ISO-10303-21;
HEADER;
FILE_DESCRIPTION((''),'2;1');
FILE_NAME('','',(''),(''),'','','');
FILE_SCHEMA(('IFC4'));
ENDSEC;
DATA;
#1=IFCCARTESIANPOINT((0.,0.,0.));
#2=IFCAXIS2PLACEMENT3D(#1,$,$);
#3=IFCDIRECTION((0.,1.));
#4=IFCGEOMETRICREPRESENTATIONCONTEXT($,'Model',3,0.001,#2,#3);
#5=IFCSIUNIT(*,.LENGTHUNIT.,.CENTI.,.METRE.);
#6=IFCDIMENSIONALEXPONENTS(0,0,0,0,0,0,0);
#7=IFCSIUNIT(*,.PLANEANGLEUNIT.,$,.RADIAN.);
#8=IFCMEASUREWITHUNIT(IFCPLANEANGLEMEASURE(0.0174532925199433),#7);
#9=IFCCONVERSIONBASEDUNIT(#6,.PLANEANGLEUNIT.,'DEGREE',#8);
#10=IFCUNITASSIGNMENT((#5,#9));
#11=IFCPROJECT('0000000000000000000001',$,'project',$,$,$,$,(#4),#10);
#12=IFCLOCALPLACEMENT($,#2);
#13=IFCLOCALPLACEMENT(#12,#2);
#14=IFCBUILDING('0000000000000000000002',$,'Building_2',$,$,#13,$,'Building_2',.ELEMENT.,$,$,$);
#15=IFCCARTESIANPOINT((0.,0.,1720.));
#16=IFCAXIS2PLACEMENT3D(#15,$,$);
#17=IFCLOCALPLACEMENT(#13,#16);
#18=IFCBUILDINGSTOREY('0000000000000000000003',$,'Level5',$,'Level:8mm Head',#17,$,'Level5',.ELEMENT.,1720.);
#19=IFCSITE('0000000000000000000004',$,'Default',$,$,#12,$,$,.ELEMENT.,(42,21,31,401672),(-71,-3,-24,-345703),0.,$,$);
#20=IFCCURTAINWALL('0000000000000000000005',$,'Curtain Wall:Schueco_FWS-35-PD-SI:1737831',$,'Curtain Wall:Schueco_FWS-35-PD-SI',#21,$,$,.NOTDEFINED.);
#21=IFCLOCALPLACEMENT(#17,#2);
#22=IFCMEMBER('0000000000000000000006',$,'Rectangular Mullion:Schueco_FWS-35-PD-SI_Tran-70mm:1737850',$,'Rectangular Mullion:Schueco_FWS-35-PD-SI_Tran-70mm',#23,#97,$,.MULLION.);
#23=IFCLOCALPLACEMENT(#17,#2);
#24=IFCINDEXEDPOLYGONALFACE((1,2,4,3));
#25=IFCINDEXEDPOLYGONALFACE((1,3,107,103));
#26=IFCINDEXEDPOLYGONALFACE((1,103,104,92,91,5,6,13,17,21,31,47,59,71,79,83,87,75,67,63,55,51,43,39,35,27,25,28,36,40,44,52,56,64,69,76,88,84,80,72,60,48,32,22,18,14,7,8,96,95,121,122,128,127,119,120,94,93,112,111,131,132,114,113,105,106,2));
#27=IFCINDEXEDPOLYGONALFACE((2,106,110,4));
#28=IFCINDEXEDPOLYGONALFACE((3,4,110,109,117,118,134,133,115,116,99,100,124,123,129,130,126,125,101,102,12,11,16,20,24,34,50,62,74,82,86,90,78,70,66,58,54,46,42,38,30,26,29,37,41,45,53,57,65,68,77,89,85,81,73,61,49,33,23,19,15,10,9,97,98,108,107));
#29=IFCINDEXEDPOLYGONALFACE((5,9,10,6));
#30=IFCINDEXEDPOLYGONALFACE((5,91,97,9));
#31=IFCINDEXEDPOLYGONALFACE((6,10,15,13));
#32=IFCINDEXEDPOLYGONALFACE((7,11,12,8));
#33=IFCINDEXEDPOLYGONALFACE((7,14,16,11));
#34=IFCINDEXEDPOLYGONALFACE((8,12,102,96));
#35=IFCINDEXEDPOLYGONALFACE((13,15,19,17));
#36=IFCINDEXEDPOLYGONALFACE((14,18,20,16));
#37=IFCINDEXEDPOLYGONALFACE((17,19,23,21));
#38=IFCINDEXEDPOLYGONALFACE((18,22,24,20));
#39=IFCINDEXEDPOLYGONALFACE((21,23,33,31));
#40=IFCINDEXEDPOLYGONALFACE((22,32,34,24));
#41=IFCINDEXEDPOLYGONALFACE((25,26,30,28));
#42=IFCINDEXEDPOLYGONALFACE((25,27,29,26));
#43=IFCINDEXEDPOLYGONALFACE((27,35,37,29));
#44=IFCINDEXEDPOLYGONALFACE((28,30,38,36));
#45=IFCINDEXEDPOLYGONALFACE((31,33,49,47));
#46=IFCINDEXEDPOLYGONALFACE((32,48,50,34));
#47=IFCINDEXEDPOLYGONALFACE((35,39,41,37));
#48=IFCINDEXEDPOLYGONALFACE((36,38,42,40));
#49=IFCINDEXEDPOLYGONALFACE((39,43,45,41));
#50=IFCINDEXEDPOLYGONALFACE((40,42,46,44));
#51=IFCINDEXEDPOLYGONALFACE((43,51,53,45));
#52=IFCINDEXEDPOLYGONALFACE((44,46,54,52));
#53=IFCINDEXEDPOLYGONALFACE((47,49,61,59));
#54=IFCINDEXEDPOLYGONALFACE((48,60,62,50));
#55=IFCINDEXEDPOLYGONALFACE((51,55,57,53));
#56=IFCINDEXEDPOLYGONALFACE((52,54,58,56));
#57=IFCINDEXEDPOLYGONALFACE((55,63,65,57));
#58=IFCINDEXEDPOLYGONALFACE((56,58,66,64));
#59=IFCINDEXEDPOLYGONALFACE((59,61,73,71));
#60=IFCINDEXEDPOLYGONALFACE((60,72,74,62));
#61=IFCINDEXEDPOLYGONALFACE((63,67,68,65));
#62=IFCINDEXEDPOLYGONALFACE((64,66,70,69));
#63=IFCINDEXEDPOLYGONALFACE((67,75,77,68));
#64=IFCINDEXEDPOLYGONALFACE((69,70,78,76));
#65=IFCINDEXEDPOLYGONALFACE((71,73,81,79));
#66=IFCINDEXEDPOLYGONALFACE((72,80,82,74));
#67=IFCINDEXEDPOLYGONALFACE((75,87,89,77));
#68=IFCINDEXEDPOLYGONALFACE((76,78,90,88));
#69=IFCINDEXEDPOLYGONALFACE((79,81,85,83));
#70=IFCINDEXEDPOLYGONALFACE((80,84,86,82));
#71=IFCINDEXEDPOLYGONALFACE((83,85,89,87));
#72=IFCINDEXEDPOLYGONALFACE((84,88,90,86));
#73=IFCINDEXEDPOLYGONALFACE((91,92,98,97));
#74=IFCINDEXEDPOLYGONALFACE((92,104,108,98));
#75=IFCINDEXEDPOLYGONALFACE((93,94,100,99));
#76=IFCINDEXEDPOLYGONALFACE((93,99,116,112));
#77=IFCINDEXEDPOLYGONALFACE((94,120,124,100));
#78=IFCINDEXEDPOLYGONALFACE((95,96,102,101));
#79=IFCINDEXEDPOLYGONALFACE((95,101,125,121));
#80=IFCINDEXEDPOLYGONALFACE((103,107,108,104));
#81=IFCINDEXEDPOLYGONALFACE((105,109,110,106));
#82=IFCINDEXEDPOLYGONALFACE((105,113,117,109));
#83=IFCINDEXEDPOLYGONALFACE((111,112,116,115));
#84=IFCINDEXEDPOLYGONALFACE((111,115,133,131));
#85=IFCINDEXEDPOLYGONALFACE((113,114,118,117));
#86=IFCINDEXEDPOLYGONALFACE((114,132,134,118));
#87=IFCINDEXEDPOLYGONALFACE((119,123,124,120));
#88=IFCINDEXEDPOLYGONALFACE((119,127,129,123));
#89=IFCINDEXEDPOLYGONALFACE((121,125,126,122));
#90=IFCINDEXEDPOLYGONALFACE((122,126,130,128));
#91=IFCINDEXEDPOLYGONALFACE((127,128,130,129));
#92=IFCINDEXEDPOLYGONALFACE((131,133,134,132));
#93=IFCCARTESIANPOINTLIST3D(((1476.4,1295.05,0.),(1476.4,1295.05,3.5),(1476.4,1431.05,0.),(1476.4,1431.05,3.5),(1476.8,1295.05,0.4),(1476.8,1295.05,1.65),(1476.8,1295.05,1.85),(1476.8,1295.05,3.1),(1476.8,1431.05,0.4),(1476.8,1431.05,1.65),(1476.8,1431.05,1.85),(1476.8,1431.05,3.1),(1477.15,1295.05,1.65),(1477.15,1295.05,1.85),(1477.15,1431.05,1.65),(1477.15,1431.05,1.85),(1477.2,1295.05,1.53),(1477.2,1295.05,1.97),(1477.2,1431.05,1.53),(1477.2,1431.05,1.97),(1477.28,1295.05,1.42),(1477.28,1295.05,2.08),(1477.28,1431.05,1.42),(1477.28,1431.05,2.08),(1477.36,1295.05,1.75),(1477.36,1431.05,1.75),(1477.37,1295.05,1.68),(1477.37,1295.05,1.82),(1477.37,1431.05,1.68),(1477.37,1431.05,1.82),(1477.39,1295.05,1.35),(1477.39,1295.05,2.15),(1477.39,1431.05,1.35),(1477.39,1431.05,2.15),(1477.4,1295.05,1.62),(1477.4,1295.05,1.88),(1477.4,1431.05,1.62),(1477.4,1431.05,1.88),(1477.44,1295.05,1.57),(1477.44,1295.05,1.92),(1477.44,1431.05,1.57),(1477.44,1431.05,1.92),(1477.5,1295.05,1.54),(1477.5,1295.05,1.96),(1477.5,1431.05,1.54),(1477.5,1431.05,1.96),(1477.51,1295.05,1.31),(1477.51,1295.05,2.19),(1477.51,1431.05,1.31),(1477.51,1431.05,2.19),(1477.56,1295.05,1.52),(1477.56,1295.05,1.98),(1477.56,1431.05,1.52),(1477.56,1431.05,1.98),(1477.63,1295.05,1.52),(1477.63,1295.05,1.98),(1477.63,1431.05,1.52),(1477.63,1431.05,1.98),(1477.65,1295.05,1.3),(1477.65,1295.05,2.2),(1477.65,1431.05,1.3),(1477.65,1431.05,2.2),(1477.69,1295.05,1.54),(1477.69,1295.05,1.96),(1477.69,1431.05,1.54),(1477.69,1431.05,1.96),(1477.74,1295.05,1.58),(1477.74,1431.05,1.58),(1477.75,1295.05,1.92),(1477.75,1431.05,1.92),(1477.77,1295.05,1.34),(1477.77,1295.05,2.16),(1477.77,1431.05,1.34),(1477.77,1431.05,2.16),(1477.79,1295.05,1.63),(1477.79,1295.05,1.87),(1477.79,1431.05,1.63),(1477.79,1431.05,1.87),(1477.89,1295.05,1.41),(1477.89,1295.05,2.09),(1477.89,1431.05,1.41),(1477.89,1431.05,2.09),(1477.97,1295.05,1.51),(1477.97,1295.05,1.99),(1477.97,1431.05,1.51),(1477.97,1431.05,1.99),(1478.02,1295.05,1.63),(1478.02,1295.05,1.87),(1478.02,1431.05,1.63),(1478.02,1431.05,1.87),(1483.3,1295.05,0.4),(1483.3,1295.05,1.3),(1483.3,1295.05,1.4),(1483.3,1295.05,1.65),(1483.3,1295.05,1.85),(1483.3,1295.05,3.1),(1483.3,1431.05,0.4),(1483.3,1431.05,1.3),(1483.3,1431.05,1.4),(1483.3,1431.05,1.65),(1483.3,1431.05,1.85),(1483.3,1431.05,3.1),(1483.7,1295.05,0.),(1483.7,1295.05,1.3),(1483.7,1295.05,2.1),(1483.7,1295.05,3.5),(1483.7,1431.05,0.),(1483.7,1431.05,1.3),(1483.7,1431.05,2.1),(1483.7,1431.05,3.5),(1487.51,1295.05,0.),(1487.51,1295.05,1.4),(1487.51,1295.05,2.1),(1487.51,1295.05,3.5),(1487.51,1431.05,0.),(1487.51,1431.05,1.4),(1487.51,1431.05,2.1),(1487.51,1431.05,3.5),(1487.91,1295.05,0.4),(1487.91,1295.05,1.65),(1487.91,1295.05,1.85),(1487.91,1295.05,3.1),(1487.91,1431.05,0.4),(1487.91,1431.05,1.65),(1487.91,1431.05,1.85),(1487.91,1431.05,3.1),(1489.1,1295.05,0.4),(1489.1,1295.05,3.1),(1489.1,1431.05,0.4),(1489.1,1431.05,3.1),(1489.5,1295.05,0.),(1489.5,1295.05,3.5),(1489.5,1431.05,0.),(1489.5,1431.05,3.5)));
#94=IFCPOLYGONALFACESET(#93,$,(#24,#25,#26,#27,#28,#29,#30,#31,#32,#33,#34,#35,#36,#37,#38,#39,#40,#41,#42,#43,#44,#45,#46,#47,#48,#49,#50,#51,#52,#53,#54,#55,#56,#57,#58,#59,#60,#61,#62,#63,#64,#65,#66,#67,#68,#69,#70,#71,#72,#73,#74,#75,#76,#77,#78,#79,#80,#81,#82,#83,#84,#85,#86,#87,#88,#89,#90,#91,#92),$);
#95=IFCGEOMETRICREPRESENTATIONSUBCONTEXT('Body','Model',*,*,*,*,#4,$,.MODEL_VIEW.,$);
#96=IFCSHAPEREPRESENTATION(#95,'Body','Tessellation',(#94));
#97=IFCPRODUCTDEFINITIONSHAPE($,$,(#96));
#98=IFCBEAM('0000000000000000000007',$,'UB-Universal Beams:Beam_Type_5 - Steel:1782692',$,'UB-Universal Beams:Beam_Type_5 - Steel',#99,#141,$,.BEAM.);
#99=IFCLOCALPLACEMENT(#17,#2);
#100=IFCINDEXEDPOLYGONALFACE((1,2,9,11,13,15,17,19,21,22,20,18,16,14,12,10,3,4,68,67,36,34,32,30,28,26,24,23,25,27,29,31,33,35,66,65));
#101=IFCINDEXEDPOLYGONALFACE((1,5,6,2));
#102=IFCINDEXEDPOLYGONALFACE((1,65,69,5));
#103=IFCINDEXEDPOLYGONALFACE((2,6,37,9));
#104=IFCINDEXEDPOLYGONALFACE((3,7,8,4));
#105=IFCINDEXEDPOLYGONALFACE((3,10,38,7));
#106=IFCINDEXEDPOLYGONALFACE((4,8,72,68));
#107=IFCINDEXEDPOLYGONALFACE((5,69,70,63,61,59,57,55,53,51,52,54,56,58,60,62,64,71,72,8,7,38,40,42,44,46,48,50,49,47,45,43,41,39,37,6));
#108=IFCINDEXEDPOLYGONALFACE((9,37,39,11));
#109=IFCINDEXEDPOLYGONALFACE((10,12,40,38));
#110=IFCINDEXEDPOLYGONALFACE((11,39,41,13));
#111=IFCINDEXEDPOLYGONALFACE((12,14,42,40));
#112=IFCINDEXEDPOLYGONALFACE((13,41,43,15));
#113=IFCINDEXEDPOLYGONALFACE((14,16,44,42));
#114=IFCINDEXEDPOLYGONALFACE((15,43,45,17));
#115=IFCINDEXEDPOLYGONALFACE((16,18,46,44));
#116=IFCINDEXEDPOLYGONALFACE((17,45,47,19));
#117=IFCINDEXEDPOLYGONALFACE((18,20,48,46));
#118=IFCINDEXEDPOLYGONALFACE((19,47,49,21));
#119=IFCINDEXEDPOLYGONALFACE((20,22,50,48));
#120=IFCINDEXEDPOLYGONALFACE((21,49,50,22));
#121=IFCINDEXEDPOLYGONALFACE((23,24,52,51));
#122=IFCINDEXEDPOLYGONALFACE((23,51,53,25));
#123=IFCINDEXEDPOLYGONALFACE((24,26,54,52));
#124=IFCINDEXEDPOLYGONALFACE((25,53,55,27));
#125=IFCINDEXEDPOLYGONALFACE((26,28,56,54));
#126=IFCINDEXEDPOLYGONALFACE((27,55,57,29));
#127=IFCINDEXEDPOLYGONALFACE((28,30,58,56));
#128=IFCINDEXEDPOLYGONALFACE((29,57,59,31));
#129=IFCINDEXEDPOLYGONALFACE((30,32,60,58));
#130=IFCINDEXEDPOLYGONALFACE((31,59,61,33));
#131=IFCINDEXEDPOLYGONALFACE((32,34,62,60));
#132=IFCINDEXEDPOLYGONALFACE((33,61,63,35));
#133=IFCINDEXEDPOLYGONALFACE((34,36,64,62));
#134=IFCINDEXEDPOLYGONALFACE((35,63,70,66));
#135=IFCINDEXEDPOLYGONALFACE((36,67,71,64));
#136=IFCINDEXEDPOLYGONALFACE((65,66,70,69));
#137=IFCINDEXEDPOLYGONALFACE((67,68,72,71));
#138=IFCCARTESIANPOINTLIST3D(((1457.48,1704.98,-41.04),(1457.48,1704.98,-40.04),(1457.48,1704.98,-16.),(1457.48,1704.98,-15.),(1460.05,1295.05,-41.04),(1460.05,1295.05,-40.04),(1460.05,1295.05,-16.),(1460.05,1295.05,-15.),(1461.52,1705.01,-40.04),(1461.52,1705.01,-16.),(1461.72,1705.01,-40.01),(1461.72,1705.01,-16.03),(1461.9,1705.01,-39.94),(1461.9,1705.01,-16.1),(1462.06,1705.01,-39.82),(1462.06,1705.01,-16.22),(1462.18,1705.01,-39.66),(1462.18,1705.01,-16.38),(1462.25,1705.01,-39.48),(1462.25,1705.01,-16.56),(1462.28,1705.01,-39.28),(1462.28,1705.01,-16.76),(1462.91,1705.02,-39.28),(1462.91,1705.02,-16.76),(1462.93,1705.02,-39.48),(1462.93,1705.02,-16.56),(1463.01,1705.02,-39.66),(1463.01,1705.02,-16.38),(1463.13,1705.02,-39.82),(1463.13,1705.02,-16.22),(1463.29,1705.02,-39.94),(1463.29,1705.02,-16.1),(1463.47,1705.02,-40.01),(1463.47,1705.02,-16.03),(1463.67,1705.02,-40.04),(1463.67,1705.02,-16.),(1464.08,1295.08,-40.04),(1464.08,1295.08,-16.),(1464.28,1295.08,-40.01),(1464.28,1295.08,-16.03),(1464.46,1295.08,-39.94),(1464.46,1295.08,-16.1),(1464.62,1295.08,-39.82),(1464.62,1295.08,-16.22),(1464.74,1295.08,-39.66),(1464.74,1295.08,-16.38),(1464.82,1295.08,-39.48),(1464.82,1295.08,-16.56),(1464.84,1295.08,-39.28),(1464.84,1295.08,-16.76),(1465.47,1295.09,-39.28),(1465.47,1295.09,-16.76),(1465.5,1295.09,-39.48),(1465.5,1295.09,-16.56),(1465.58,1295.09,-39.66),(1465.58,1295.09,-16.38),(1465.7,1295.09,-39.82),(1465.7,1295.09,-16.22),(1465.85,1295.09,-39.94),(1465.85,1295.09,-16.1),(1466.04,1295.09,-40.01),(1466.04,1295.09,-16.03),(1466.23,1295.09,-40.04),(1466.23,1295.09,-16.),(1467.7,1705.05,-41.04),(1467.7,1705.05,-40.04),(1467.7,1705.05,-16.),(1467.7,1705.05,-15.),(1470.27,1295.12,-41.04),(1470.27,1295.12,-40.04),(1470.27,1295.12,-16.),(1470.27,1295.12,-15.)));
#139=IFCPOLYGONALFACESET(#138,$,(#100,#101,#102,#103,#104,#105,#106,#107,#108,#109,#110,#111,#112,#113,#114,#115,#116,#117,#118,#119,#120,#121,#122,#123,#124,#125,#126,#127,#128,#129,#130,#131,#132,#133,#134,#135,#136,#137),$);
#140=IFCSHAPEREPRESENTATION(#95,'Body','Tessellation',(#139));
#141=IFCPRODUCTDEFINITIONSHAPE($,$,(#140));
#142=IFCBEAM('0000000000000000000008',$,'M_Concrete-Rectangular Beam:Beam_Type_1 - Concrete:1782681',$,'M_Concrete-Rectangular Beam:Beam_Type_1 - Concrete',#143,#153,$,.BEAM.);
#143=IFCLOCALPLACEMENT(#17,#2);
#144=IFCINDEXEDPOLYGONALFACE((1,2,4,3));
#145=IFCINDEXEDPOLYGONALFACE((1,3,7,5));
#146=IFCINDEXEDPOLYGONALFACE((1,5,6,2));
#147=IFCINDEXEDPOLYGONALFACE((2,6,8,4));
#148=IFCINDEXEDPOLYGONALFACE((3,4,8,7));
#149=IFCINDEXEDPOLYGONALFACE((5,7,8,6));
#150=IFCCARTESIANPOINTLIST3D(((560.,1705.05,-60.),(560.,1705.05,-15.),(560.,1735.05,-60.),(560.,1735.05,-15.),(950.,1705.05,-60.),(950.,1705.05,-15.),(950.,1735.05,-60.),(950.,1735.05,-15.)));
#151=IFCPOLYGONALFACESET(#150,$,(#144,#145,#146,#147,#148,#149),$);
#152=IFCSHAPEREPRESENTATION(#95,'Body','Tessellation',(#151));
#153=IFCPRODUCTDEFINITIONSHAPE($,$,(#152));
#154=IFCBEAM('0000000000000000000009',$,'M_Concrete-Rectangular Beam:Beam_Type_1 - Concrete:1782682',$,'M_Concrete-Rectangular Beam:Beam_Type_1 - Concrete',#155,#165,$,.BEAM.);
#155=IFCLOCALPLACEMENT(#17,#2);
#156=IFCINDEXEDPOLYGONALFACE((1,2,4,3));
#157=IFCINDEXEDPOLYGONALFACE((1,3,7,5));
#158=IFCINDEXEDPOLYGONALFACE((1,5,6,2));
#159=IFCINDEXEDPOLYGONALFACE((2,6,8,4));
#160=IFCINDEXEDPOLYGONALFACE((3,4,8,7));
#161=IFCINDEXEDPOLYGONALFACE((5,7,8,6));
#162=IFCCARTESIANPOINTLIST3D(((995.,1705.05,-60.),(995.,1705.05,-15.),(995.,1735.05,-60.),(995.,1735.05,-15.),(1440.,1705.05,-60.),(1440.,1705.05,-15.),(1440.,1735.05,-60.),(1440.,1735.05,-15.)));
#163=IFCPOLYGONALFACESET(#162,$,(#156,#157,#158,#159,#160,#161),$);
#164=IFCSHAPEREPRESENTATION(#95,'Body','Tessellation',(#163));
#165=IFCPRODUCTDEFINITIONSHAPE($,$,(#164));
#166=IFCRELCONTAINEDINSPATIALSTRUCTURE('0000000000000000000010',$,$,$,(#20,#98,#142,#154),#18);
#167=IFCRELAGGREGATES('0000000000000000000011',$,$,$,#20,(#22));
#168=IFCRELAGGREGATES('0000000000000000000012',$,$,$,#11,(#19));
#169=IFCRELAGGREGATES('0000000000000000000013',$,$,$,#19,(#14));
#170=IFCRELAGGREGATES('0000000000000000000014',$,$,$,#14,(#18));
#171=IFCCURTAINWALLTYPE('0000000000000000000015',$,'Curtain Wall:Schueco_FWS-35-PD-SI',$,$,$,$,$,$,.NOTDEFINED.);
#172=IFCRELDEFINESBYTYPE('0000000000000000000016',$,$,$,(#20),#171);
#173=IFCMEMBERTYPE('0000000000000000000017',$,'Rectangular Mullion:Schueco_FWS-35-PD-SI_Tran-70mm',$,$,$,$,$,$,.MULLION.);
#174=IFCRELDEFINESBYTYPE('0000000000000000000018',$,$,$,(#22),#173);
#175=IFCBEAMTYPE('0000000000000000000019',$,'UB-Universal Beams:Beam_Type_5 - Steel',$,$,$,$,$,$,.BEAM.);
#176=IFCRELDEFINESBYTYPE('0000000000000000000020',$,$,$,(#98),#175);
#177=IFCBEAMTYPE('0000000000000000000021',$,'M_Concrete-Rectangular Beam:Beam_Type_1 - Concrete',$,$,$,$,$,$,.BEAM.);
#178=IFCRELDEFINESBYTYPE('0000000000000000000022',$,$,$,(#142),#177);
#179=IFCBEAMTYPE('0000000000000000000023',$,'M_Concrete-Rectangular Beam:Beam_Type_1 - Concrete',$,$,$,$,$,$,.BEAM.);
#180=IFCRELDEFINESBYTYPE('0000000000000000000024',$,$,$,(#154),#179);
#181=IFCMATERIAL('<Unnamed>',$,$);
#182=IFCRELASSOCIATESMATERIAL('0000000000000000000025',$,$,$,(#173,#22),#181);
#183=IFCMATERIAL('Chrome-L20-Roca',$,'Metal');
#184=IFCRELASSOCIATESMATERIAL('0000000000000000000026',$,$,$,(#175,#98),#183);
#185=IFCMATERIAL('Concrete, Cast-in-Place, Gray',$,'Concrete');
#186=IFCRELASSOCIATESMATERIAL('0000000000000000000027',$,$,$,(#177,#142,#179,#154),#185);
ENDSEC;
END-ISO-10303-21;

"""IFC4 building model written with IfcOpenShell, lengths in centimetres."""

from ifc_helpers import new_model, entity, si_unit, converted_unit, direction, frame, origin, place, context, subcontext, project, spatial, line, arc, indexed_curve, outline, extrude, source, transform, mapped, material, type_object, type_shapes, element, aggregate, save


model = new_model("IFC4")

# Units and contexts
model_context = context("Model", 3, precision=0.001, world=origin(), true_north=direction((0.0, 1.0)))
body_context = subcontext(model_context, "Body", "Model", "MODEL_VIEW")
ifc_project = project(units=[si_unit("LENGTHUNIT", "METRE", prefix="CENTI"), converted_unit("PLANEANGLEUNIT", "DEGREE", entity("IfcPlaneAngleMeasure", 0.0174532925199433), si_unit("PLANEANGLEUNIT", "RADIAN"), dimensions=[0, 0, 0, 0, 0, 0, 0])], contexts=[model_context])

# Site, building, storey
site_placement = place(None, origin())
site = spatial("IfcSite", under=ifc_project, at=site_placement, Name="Default", CompositionType="ELEMENT", RefLatitude=(42, 21, 31, 401672), RefLongitude=(-71, -3, -24, -345703), RefElevation=0.0)
building_placement = place(site_placement, origin())
building = spatial("IfcBuilding", under=site, at=building_placement, Name="Building_2", LongName="Building_2", CompositionType="ELEMENT")
storey_placement = place(building_placement, frame((0.0, 0.0, 1720.0)))
storey = spatial("IfcBuildingStorey", under=building, at=storey_placement, Name="Level5", ObjectType="Level:8mm Head", LongName="Level5", CompositionType="ELEMENT", Elevation=1720.0)

# Curtain wall, member
curtain_wall_type = type_object("IfcCurtainWallType", Name="Curtain Wall:Schueco_FWS-35-PD-SI", PredefinedType="NOTDEFINED")
curtain_wall_placement = place(storey_placement, frame((0.0, 0.0, -1720.0)))
curtain_wall = element("IfcCurtainWall", 1, at=curtain_wall_placement, inside=storey, type_object=curtain_wall_type, Name="Curtain Wall:Schueco_FWS-35-PD-SI:1737831", ObjectType="Curtain Wall:Schueco_FWS-35-PD-SI", PredefinedType="NOTDEFINED")
ifc_material_1 = material(Name="<Unnamed>")
member_type_1 = type_object("IfcMemberType", Name="Rectangular Mullion:Schueco_FWS-35-PD-SI_Tran-70mm", PredefinedType="MULLION", material=ifc_material_1)
shared_shape_1 = source(origin(), body_context, "Body", "SweptSolid", [
    extrude(outline(indexed_curve([(-6.52, -1.78), (0.78, -1.78), (0.78, -0.38), (4.59, -0.38), (4.59, -1.78), (6.58, -1.78), (6.58, 1.72), (4.59, 1.72), (4.59, 0.32), (0.38, 0.32), (0.38, 0.07), (4.99, 0.07), (4.99, 1.32), (6.18, 1.32), (6.18, -1.38), (4.99, -1.38), (4.99, -0.13), (0.38, -0.13), (0.38, -1.38), (-6.12, -1.38), (-6.12, -0.13), (-5.77, -0.13), (-5.34, -0.48), (-4.9, -0.15), (-5.14, -0.15), (-5.56, -0.03), (-5.14, 0.09), (-4.9, 0.09), (-5.34, 0.42), (-5.77, 0.07), (-6.12, 0.07), (-6.12, 1.32), (0.38, 1.32), (0.38, 0.42), (0.78, 0.42), (0.78, 1.72), (-6.52, 1.72)], segments=[line(1, 2, 3, 4, 5, 6, 7, 8, 9, 10, 11, 12, 13, 14, 15, 16, 17, 18, 19, 20, 21, 22), arc(22, 23, 24), line(24, 25), arc(25, 26, 27), line(27, 28), arc(28, 29, 30), line(30, 31, 32, 33, 34, 35, 36, 37, 1)], self_intersect=False)), frame((-1.72, 4.58, -136.0), z_axis=(0.0, 0.0, 1.0), x_axis=(0.0, -1.0, 0.0)), (0.0, 0.0, 1.0), 136.0),
])
type_shapes(member_type_1, [shared_shape_1])
member_1_placement = place(curtain_wall_placement, frame((1487.5, 1431.05, 1720.0), z_axis=(0.0, 1.0, 0.0), x_axis=(0.0, 0.0, -1.0)))
member_1 = element("IfcMember", 2, at=member_1_placement, type_object=member_type_1, material=ifc_material_1, Name="Rectangular Mullion:Schueco_FWS-35-PD-SI_Tran-70mm:1737850", ObjectType="Rectangular Mullion:Schueco_FWS-35-PD-SI_Tran-70mm", PredefinedType="MULLION", context=body_context, shape_type="MappedRepresentation", body=[
    mapped(shared_shape_1, transform((0.0, 0.0, 0.0), scale=1.0)),
])

# Beams
ifc_material_2 = material(Name="Chrome-L20-Roca", Category="Metal")
beam_type_1 = type_object("IfcBeamType", Name="UB-Universal Beams:Beam_Type_5 - Steel", PredefinedType="BEAM", material=ifc_material_2)
shared_shape_2 = source(origin(), body_context, "Body", "SweptSolid", [
    extrude(outline(indexed_curve([(-5.11, -12.02), (-5.11, -13.02), (5.11, -13.02), (5.11, -12.02), (1.08, -12.02), (0.54, -11.8), (0.31, -11.26), (0.31, 11.26), (0.54, 11.8), (1.07, 12.02), (5.11, 12.02), (5.11, 13.02), (-5.11, 13.02), (-5.11, 12.02), (-1.08, 12.02), (-0.54, 11.8), (-0.32, 11.26), (-0.32, -11.26), (-0.54, -11.8), (-1.08, -12.02)], segments=[line(1, 2, 3, 4, 5), arc(5, 6, 7), line(7, 8), arc(8, 9, 10), line(10, 11, 12, 13, 14, 15), arc(15, 16, 17), line(17, 18), arc(18, 19, 20), line(20, 1)], self_intersect=False)), frame((-199.97, 0.0, 0.0), z_axis=(-1.0, 0.0, 0.0), x_axis=(0.0, -1.0, 0.0)), (0.0, 0.0, -1.0), 409.94),
])
type_shapes(beam_type_1, [shared_shape_2])
beam_1_placement = place(storey_placement, frame((1463.85, 1505.05, -28.02), z_axis=(0.0, 0.0, 1.0), x_axis=(0.006256, -0.99998, 0.0)))
element("IfcBeam", 3, at=beam_1_placement, inside=storey, type_object=beam_type_1, material=ifc_material_2, Name="UB-Universal Beams:Beam_Type_5 - Steel:1782692", ObjectType="UB-Universal Beams:Beam_Type_5 - Steel", PredefinedType="BEAM", context=body_context, shape_type="MappedRepresentation", body=[
    mapped(shared_shape_2, transform((0.0, 0.0, 0.0), scale=1.0)),
])
ifc_material_3 = material(Name="Concrete, Cast-in-Place, Gray", Category="Concrete")
beam_type_2 = type_object("IfcBeamType", Name="M_Concrete-Rectangular Beam:Beam_Type_1 - Concrete", PredefinedType="BEAM", material=ifc_material_3)
shared_shape_3 = source(origin(), body_context, "Body", "SweptSolid", [
    extrude(outline(indexed_curve([(-22.5, -15.0), (22.5, -15.0), (22.5, 15.0), (-22.5, 15.0), (-22.5, -15.0)], self_intersect=False)), frame((560.0, 1720.05, 1682.5), z_axis=(1.0, 0.0, 0.0), x_axis=(0.0, 0.0, -1.0)), (0.0, 0.0, 1.0), 390.0),
])
type_shapes(beam_type_2, [shared_shape_3])
beam_2_placement = place(storey_placement, frame((0.0, 0.0, -1720.0)))
element("IfcBeam", 4, at=beam_2_placement, inside=storey, type_object=beam_type_2, material=ifc_material_3, Name="M_Concrete-Rectangular Beam:Beam_Type_1 - Concrete:1782681", ObjectType="M_Concrete-Rectangular Beam:Beam_Type_1 - Concrete", PredefinedType="BEAM", context=body_context, shape_type="MappedRepresentation", body=[
    mapped(shared_shape_3, transform((0.0, 0.0, 0.0), scale=1.0)),
])
beam_type_3 = type_object("IfcBeamType", Name="M_Concrete-Rectangular Beam:Beam_Type_1 - Concrete", PredefinedType="BEAM", material=ifc_material_3)
shared_shape_4 = source(origin(), body_context, "Body", "SweptSolid", [
    extrude(outline(indexed_curve([(-22.5, -15.0), (22.5, -15.0), (22.5, 15.0), (-22.5, 15.0), (-22.5, -15.0)], self_intersect=False)), frame((995.0, 1720.05, 1682.5), z_axis=(1.0, 0.0, 0.0), x_axis=(0.0, 0.0, -1.0)), (0.0, 0.0, 1.0), 445.0),
])
type_shapes(beam_type_3, [shared_shape_4])
beam_3_placement = place(storey_placement, frame((0.0, 0.0, -1720.0)))
element("IfcBeam", 5, at=beam_3_placement, inside=storey, type_object=beam_type_3, material=ifc_material_3, Name="M_Concrete-Rectangular Beam:Beam_Type_1 - Concrete:1782682", ObjectType="M_Concrete-Rectangular Beam:Beam_Type_1 - Concrete", PredefinedType="BEAM", context=body_context, shape_type="MappedRepresentation", body=[
    mapped(shared_shape_4, transform((0.0, 0.0, 0.0), scale=1.0)),
])

aggregate(curtain_wall, [member_1])

save(model, "model.ifc")
